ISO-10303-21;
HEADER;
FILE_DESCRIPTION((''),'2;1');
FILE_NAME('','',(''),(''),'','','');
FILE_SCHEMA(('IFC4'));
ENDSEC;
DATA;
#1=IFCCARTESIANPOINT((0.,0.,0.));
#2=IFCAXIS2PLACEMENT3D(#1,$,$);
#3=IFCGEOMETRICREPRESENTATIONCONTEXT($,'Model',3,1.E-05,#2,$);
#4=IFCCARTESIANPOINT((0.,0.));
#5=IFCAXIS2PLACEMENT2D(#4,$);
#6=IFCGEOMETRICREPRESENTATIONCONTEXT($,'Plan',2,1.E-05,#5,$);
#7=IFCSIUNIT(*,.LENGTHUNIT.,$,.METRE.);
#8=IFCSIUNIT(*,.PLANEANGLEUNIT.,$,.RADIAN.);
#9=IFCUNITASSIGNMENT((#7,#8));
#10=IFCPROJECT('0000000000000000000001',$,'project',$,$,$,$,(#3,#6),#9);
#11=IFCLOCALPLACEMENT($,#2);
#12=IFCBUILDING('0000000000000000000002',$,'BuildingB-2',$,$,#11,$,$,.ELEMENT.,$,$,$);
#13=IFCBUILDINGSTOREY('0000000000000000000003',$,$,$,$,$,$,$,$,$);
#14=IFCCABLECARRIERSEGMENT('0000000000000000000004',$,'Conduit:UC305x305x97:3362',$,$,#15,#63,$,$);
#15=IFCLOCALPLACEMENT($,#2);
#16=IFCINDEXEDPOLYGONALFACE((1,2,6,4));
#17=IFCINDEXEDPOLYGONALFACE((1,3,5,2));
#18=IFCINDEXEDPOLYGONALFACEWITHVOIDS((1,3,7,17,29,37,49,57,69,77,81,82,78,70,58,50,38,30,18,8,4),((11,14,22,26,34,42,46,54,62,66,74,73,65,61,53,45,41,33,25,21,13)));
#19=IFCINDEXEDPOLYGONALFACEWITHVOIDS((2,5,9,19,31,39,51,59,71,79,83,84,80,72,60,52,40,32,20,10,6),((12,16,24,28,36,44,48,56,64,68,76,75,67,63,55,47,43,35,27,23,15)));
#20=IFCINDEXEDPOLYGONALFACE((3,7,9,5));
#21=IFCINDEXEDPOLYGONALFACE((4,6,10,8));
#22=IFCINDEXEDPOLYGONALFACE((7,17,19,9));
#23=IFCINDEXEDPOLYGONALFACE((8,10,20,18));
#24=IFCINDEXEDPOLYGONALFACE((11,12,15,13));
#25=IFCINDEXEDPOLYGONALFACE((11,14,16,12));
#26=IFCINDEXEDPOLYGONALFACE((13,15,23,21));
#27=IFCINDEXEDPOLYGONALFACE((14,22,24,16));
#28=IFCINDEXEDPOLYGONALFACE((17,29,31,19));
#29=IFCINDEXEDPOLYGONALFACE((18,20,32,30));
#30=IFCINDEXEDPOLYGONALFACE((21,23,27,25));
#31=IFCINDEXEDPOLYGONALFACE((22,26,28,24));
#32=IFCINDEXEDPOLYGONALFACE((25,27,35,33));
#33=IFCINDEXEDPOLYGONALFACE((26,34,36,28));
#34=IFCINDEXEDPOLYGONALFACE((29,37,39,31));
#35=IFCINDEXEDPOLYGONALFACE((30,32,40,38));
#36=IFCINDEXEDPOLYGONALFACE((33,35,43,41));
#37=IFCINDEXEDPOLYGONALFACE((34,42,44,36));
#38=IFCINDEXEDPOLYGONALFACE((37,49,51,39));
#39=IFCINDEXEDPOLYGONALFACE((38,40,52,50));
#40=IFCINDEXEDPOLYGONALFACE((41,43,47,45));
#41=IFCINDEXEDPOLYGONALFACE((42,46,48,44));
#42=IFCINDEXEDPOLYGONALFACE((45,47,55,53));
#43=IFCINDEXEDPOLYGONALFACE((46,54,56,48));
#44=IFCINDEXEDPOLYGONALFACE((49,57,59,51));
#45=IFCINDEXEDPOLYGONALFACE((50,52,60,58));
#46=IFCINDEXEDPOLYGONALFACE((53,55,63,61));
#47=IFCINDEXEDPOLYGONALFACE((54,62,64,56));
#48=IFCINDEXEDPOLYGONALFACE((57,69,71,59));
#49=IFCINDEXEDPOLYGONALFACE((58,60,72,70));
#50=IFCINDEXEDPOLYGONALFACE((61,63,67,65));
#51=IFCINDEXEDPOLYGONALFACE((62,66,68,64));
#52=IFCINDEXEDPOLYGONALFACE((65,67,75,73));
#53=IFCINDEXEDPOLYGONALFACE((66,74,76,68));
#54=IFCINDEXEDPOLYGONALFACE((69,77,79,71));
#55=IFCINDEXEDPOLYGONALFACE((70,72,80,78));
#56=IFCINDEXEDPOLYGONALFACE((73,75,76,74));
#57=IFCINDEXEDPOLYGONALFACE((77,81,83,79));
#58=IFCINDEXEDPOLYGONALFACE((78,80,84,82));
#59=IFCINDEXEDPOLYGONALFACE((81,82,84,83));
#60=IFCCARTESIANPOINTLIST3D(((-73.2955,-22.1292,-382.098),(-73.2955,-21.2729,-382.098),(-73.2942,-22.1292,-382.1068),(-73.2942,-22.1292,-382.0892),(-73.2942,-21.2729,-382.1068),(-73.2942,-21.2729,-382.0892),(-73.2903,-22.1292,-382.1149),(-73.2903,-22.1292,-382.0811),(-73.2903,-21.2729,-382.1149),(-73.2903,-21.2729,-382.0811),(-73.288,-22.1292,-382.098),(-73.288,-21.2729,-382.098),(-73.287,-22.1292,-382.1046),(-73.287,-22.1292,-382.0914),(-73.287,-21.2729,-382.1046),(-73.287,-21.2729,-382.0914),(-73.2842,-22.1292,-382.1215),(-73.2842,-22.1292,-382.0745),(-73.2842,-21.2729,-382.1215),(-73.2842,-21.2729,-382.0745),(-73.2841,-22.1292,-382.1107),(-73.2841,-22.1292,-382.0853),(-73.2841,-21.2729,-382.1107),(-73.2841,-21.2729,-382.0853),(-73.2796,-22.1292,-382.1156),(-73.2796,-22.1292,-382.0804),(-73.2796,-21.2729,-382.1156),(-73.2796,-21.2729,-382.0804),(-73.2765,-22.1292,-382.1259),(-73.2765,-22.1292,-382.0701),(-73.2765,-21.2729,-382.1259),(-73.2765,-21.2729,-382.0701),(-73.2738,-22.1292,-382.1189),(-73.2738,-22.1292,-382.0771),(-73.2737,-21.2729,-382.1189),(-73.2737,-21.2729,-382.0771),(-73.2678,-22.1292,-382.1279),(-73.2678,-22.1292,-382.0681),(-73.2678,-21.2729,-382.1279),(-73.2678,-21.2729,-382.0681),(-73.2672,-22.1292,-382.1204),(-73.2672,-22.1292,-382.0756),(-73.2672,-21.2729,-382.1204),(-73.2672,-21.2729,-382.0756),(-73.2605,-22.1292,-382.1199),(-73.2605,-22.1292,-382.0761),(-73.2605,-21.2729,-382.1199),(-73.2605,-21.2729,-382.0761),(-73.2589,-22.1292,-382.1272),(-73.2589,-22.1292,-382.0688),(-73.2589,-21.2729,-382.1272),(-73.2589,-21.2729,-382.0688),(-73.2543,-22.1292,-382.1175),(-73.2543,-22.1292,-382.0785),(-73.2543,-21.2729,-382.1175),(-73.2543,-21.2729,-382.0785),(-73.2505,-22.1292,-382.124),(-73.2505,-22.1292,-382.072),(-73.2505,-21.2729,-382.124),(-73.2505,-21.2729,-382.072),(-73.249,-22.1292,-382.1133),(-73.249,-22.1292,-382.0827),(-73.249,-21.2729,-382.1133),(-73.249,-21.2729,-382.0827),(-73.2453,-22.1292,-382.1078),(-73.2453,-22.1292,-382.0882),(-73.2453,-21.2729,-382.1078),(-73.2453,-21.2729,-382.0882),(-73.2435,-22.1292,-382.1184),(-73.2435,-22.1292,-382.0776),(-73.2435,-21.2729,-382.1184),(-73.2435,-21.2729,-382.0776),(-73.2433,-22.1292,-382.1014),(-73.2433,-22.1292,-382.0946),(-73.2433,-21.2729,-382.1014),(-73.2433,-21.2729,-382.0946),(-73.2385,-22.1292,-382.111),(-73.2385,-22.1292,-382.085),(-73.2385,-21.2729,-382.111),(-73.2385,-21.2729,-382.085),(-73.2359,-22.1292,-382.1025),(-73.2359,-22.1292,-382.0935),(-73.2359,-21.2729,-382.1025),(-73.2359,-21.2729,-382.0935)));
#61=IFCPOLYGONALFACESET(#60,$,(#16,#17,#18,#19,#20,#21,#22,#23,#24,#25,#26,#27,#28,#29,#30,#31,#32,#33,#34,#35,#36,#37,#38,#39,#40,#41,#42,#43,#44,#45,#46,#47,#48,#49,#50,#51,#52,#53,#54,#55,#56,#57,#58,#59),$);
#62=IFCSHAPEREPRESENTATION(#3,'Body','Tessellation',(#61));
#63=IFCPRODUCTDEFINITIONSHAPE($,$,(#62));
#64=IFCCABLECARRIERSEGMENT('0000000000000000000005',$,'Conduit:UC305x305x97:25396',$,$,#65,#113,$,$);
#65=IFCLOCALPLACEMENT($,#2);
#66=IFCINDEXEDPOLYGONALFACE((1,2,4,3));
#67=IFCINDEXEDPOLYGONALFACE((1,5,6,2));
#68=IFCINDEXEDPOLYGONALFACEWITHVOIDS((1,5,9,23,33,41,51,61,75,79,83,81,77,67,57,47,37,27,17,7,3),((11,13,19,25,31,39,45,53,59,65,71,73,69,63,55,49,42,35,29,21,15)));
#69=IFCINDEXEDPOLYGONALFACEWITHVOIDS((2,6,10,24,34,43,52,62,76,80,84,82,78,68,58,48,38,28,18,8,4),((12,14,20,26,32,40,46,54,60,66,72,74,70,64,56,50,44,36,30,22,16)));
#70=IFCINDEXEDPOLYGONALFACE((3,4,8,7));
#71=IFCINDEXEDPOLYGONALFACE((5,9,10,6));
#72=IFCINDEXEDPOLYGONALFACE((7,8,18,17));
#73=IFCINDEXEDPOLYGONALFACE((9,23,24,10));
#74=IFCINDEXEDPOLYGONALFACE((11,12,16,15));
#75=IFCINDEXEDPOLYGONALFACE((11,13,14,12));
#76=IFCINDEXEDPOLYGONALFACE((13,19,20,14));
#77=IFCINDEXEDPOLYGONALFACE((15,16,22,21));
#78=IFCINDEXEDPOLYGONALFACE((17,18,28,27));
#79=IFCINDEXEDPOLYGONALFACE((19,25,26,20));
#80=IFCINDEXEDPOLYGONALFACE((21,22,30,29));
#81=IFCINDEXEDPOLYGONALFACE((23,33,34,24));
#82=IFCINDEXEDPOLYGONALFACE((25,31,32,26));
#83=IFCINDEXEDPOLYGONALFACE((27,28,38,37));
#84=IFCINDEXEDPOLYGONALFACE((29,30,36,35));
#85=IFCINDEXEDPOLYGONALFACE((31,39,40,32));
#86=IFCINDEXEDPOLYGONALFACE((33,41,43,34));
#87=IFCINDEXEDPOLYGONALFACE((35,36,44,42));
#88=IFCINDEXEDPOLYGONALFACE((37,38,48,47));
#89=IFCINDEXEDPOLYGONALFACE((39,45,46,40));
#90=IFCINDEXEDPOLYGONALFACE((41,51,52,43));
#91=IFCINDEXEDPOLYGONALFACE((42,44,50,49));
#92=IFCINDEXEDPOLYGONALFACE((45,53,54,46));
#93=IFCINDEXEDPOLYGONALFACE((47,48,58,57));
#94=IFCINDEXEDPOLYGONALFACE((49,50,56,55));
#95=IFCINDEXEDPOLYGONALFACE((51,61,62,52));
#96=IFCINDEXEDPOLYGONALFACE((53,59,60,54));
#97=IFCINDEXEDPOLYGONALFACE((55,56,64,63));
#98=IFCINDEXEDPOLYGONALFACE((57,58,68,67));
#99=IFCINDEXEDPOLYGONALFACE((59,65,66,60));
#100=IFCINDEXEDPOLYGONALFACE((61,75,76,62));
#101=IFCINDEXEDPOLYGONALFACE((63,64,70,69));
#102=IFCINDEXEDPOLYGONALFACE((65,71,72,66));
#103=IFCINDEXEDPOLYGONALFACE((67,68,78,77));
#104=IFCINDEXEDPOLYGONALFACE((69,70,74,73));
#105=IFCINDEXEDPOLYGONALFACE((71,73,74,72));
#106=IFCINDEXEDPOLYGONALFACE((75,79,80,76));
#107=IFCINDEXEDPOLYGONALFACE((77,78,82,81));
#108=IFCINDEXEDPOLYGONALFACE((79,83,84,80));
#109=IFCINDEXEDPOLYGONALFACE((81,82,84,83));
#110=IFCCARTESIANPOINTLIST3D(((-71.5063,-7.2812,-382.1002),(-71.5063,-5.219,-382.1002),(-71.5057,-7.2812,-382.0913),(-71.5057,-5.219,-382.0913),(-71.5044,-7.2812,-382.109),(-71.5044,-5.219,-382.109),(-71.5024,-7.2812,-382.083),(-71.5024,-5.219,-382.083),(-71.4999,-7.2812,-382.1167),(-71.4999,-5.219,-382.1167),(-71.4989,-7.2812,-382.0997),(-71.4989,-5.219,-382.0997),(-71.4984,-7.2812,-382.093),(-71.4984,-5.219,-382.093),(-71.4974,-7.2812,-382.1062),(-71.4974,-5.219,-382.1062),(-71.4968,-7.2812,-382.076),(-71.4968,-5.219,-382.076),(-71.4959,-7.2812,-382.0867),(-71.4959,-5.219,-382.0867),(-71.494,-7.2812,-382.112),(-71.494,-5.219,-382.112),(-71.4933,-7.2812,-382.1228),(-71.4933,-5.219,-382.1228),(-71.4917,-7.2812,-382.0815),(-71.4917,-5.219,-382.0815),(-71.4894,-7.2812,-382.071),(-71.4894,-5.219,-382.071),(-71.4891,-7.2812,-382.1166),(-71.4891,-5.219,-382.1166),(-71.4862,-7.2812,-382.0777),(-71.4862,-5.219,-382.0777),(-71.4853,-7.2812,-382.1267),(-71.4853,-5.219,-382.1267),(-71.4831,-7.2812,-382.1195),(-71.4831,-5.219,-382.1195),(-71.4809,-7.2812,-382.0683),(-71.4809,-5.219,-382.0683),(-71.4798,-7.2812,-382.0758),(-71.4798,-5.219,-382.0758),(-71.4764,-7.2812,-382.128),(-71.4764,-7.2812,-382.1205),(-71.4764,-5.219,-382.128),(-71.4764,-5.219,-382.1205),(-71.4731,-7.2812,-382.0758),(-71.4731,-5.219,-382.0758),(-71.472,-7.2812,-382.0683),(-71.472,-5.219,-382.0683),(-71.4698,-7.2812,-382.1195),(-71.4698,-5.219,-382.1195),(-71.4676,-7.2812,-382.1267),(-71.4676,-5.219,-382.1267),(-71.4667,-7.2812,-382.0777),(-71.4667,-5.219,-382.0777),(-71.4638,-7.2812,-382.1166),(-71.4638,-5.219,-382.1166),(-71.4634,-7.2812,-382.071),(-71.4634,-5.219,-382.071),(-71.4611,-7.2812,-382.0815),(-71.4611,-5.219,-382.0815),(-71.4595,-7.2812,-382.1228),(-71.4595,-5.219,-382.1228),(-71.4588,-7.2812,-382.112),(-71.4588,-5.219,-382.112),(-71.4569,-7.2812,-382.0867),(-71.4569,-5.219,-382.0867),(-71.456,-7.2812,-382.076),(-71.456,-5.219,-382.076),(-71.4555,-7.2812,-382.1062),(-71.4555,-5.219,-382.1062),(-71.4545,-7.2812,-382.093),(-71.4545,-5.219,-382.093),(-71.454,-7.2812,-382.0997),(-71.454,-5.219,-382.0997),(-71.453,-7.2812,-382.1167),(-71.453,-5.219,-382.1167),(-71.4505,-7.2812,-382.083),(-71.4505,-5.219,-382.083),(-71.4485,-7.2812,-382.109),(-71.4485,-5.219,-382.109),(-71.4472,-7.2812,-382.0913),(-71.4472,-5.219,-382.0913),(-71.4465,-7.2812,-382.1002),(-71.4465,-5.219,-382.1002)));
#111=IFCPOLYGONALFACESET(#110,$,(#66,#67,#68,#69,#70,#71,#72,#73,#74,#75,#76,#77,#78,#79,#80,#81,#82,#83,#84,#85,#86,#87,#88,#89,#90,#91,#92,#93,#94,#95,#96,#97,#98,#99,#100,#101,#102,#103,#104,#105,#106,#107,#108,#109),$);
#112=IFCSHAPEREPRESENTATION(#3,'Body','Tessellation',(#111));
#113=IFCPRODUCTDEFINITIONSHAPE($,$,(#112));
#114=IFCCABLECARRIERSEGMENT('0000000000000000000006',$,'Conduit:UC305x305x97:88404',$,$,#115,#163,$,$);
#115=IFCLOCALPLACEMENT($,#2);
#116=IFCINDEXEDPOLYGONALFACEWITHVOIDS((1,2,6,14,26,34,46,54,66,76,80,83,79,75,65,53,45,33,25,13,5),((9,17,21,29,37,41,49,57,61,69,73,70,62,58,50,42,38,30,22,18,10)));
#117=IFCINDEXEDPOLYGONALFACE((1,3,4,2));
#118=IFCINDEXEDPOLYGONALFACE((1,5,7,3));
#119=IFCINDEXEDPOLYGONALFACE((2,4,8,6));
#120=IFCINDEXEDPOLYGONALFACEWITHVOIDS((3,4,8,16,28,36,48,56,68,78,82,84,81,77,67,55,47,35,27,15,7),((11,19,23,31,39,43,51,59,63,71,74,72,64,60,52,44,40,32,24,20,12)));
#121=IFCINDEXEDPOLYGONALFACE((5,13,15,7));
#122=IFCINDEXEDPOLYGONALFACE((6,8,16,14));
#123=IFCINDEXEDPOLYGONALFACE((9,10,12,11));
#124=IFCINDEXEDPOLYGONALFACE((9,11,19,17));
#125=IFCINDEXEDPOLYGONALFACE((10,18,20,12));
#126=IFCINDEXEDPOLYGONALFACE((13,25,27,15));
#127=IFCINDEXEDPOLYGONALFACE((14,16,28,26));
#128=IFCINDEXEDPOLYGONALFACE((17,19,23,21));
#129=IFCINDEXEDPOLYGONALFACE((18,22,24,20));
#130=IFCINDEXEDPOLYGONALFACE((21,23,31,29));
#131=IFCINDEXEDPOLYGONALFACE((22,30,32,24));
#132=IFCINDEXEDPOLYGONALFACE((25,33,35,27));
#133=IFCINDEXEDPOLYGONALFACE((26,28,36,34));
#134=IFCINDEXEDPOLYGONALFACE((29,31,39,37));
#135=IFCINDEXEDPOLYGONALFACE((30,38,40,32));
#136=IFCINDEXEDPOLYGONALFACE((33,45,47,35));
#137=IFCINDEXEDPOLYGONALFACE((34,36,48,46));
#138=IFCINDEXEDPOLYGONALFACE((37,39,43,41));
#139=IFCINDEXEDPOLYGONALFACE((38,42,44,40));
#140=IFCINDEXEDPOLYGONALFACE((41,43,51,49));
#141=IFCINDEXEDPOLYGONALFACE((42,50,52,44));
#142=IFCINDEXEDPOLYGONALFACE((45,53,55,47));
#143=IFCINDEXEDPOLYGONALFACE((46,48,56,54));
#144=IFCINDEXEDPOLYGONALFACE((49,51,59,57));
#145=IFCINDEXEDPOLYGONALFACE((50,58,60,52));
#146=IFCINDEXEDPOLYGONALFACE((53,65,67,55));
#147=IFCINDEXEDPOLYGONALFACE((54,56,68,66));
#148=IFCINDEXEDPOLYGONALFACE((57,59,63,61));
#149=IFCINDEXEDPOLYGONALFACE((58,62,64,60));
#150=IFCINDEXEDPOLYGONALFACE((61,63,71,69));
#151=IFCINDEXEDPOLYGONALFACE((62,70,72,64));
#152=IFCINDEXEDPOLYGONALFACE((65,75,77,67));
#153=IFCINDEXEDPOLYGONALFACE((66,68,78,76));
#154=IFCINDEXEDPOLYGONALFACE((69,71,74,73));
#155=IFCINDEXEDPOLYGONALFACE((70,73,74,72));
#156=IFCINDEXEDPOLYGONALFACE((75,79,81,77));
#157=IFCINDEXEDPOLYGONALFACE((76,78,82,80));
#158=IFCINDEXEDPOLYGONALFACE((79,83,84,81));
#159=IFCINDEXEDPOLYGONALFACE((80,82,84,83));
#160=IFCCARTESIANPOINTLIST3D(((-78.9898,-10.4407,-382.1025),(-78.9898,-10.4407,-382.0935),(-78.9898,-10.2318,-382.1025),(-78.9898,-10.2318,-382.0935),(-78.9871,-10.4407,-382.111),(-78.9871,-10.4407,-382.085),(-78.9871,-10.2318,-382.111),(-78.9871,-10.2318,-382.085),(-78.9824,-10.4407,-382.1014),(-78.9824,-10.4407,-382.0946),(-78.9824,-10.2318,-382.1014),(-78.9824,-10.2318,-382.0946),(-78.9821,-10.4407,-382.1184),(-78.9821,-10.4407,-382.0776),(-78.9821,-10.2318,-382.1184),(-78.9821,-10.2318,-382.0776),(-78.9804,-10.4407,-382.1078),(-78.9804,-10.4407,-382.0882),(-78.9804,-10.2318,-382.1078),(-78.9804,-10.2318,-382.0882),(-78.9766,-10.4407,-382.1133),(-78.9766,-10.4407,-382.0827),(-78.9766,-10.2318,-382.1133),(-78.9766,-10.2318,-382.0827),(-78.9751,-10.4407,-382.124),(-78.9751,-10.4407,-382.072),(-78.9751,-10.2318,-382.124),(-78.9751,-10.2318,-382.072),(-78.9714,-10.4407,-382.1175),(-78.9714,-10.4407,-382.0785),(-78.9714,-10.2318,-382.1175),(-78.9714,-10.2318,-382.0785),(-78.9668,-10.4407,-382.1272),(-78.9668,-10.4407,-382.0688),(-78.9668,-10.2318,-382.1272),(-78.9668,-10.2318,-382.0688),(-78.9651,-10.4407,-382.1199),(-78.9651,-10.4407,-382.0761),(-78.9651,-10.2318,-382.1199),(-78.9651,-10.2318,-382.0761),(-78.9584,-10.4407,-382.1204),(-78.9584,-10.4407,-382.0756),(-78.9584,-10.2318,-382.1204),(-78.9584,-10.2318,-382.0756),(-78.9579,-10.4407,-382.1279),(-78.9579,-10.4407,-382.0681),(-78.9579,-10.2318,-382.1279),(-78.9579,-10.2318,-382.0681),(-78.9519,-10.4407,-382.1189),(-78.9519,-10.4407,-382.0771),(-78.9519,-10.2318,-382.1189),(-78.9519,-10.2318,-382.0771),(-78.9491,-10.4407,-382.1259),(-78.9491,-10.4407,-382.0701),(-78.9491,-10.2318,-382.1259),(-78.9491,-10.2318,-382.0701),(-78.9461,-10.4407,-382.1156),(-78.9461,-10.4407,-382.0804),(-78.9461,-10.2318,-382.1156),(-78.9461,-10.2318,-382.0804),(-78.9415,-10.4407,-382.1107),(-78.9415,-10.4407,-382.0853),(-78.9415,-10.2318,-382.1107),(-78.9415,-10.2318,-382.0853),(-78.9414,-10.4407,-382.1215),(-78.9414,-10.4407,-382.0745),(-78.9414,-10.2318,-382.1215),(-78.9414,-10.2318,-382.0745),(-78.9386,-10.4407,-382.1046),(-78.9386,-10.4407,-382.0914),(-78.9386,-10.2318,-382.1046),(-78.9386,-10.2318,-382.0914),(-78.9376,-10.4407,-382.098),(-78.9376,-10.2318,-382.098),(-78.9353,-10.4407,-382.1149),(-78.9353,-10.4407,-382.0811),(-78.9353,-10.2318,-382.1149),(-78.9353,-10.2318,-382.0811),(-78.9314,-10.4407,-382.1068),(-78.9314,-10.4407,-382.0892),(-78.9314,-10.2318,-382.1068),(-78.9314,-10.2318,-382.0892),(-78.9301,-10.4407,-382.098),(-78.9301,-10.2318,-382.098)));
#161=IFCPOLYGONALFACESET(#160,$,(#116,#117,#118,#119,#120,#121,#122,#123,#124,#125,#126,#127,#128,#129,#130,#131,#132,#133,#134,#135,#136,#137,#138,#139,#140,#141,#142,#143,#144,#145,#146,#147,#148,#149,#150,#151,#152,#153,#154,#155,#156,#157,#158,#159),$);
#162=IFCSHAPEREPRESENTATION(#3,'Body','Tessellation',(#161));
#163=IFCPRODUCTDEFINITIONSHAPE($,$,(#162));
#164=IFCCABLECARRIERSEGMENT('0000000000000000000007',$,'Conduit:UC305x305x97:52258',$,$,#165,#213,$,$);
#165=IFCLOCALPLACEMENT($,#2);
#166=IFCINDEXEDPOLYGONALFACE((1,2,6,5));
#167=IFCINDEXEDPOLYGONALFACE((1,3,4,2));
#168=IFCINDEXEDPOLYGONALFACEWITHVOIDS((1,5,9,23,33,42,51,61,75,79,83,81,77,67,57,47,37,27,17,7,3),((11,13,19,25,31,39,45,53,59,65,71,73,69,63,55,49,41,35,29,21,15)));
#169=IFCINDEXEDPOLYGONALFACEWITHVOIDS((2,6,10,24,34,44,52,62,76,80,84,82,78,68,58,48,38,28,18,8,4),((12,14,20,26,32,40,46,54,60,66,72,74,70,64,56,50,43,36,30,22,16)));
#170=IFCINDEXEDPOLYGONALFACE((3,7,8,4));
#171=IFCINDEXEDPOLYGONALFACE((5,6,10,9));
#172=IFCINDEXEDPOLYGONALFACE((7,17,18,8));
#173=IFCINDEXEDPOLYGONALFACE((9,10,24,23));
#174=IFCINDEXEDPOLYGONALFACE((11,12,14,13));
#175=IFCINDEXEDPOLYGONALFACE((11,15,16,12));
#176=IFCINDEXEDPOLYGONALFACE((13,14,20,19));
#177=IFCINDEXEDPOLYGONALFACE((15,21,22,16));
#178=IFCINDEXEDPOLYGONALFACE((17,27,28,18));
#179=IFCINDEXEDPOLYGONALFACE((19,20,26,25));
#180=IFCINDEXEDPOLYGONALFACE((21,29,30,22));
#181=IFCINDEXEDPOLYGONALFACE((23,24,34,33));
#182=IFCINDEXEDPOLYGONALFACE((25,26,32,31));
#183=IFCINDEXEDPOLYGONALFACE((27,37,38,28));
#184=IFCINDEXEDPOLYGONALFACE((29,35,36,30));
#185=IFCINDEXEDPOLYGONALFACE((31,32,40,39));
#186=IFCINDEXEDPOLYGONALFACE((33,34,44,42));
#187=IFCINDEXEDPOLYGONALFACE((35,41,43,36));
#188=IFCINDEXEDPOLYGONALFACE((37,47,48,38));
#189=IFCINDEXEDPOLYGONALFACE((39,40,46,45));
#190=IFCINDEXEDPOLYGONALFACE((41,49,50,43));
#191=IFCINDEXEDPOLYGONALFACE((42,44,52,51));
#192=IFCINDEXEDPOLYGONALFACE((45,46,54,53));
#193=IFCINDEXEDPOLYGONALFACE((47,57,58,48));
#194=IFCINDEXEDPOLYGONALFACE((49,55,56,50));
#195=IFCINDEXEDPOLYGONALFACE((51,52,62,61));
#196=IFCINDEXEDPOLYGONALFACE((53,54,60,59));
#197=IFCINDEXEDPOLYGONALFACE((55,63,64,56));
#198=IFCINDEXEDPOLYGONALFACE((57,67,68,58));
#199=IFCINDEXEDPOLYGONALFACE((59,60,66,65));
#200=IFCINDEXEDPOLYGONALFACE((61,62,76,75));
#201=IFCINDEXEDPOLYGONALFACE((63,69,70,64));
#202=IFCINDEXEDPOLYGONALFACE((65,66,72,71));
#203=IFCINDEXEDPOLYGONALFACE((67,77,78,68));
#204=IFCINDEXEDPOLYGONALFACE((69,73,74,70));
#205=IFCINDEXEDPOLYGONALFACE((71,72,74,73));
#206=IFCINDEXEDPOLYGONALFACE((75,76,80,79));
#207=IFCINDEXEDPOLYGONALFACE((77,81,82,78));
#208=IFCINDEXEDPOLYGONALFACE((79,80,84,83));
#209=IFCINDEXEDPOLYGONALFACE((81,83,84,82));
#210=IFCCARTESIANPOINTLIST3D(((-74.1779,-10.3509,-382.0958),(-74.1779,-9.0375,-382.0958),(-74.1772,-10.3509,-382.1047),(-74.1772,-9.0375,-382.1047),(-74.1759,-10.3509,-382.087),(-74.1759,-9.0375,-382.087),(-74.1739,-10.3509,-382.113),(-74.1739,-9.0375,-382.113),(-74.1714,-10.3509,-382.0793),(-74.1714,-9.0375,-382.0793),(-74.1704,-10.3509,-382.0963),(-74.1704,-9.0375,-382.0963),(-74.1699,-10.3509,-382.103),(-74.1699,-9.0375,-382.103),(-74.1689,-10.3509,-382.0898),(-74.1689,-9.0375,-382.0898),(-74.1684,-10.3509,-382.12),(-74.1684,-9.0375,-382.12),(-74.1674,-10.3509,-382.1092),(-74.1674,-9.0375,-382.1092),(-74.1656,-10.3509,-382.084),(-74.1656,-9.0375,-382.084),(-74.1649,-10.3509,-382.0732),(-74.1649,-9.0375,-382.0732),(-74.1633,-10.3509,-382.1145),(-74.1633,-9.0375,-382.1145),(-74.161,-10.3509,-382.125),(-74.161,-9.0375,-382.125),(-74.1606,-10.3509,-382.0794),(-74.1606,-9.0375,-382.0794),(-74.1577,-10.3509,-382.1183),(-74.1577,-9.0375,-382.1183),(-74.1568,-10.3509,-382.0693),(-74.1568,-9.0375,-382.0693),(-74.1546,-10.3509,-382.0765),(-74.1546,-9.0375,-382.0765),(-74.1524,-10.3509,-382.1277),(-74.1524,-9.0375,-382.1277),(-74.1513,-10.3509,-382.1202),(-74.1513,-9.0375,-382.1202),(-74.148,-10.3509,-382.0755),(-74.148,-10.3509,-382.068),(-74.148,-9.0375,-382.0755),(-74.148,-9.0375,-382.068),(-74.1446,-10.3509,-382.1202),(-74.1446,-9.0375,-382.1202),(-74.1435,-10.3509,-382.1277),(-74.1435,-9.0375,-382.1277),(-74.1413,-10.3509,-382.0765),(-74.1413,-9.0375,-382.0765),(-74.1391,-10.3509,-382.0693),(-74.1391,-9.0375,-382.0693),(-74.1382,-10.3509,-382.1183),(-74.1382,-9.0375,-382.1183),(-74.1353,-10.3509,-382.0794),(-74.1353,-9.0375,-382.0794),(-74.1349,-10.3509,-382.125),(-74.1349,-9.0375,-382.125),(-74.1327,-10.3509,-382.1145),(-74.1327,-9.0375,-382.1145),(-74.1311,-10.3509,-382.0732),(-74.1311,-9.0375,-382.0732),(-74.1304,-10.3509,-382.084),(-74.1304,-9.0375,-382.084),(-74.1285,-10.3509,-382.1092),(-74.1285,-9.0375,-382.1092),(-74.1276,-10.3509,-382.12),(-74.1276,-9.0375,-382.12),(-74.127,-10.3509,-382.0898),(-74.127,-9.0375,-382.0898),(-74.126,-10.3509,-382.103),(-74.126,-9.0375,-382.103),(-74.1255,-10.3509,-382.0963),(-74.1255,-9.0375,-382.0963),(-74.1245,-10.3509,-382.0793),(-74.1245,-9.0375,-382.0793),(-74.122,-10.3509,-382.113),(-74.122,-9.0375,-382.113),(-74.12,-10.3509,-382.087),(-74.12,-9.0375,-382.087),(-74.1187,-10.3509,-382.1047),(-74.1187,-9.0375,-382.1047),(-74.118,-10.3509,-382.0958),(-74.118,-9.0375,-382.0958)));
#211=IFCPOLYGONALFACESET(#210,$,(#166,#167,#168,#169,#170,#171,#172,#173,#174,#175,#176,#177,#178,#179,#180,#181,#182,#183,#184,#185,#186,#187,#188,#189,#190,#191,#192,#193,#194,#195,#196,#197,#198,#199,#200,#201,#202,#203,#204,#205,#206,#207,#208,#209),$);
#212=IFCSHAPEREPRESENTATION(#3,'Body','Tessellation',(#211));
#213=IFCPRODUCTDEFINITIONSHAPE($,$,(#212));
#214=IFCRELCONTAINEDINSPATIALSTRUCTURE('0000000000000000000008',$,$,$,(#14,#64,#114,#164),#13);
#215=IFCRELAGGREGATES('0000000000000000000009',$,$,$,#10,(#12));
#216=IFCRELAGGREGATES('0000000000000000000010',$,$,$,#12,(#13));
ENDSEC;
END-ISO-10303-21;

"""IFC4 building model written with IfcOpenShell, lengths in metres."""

from ifc_helpers import new_model, entity, si_unit, origin, origin_2d, place, context, project, spatial, element, save


model = new_model("IFC4")

# Units and contexts
model_context = context("Model", 3, precision=1e-05, world=origin())
plan_context = context("Plan", 2, precision=1e-05, world=origin_2d())
ifc_project = project(units=[si_unit("LENGTHUNIT", "METRE"), si_unit("PLANEANGLEUNIT", "RADIAN")], contexts=[model_context, plan_context])

# Building, storey
building_placement = place(None, origin())
building = spatial("IfcBuilding", under=ifc_project, at=building_placement, Name="BuildingB-2", CompositionType="ELEMENT")
storey = spatial("IfcBuildingStorey", under=building)

# Cable carrier segments
element("IfcCableCarrierSegment", 1, inside=storey, Name="Conduit:UC305x305x97:3362", context=model_context, shape_type="AdvancedSweptSolid", body=[
    entity("IfcSweptDiskSolid", entity("IfcCompositeCurve", [entity("IfcCompositeCurveSegment", "CONTINUOUS", False, entity("IfcPolyline", [entity("IfcCartesianPoint", [73.2655, 22.1292, 382.098]), entity("IfcCartesianPoint", [73.2655, 21.2729, 382.098])]))], False), 0.03, 0.0225),
])
element("IfcCableCarrierSegment", 2, inside=storey, Name="Conduit:UC305x305x97:25396", context=model_context, shape_type="AdvancedSweptSolid", body=[
    entity("IfcSweptDiskSolid", entity("IfcCompositeCurve", [entity("IfcCompositeCurveSegment", "CONTINUOUS", False, entity("IfcPolyline", [entity("IfcCartesianPoint", [71.4764, 7.2812, 382.098]), entity("IfcCartesianPoint", [71.4764, 5.219, 382.098])]))], False), 0.03, 0.0225),
])
element("IfcCableCarrierSegment", 3, inside=storey, Name="Conduit:UC305x305x97:88404", context=model_context, shape_type="AdvancedSweptSolid", body=[
    entity("IfcSweptDiskSolid", entity("IfcCompositeCurve", [entity("IfcCompositeCurveSegment", "CONTINUOUS", False, entity("IfcPolyline", [entity("IfcCartesianPoint", [78.9601, 10.2318, 382.098]), entity("IfcCartesianPoint", [78.9601, 10.4407, 382.098])]))], False), 0.03, 0.0225),
])
element("IfcCableCarrierSegment", 4, inside=storey, Name="Conduit:UC305x305x97:52258", context=model_context, shape_type="AdvancedSweptSolid", body=[
    entity("IfcSweptDiskSolid", entity("IfcCompositeCurve", [entity("IfcCompositeCurveSegment", "CONTINUOUS", False, entity("IfcPolyline", [entity("IfcCartesianPoint", [74.148, 9.0375, 382.098]), entity("IfcCartesianPoint", [74.148, 10.3509, 382.098])]))], False), 0.03, 0.0225),
])

save(model, "model.ifc")
